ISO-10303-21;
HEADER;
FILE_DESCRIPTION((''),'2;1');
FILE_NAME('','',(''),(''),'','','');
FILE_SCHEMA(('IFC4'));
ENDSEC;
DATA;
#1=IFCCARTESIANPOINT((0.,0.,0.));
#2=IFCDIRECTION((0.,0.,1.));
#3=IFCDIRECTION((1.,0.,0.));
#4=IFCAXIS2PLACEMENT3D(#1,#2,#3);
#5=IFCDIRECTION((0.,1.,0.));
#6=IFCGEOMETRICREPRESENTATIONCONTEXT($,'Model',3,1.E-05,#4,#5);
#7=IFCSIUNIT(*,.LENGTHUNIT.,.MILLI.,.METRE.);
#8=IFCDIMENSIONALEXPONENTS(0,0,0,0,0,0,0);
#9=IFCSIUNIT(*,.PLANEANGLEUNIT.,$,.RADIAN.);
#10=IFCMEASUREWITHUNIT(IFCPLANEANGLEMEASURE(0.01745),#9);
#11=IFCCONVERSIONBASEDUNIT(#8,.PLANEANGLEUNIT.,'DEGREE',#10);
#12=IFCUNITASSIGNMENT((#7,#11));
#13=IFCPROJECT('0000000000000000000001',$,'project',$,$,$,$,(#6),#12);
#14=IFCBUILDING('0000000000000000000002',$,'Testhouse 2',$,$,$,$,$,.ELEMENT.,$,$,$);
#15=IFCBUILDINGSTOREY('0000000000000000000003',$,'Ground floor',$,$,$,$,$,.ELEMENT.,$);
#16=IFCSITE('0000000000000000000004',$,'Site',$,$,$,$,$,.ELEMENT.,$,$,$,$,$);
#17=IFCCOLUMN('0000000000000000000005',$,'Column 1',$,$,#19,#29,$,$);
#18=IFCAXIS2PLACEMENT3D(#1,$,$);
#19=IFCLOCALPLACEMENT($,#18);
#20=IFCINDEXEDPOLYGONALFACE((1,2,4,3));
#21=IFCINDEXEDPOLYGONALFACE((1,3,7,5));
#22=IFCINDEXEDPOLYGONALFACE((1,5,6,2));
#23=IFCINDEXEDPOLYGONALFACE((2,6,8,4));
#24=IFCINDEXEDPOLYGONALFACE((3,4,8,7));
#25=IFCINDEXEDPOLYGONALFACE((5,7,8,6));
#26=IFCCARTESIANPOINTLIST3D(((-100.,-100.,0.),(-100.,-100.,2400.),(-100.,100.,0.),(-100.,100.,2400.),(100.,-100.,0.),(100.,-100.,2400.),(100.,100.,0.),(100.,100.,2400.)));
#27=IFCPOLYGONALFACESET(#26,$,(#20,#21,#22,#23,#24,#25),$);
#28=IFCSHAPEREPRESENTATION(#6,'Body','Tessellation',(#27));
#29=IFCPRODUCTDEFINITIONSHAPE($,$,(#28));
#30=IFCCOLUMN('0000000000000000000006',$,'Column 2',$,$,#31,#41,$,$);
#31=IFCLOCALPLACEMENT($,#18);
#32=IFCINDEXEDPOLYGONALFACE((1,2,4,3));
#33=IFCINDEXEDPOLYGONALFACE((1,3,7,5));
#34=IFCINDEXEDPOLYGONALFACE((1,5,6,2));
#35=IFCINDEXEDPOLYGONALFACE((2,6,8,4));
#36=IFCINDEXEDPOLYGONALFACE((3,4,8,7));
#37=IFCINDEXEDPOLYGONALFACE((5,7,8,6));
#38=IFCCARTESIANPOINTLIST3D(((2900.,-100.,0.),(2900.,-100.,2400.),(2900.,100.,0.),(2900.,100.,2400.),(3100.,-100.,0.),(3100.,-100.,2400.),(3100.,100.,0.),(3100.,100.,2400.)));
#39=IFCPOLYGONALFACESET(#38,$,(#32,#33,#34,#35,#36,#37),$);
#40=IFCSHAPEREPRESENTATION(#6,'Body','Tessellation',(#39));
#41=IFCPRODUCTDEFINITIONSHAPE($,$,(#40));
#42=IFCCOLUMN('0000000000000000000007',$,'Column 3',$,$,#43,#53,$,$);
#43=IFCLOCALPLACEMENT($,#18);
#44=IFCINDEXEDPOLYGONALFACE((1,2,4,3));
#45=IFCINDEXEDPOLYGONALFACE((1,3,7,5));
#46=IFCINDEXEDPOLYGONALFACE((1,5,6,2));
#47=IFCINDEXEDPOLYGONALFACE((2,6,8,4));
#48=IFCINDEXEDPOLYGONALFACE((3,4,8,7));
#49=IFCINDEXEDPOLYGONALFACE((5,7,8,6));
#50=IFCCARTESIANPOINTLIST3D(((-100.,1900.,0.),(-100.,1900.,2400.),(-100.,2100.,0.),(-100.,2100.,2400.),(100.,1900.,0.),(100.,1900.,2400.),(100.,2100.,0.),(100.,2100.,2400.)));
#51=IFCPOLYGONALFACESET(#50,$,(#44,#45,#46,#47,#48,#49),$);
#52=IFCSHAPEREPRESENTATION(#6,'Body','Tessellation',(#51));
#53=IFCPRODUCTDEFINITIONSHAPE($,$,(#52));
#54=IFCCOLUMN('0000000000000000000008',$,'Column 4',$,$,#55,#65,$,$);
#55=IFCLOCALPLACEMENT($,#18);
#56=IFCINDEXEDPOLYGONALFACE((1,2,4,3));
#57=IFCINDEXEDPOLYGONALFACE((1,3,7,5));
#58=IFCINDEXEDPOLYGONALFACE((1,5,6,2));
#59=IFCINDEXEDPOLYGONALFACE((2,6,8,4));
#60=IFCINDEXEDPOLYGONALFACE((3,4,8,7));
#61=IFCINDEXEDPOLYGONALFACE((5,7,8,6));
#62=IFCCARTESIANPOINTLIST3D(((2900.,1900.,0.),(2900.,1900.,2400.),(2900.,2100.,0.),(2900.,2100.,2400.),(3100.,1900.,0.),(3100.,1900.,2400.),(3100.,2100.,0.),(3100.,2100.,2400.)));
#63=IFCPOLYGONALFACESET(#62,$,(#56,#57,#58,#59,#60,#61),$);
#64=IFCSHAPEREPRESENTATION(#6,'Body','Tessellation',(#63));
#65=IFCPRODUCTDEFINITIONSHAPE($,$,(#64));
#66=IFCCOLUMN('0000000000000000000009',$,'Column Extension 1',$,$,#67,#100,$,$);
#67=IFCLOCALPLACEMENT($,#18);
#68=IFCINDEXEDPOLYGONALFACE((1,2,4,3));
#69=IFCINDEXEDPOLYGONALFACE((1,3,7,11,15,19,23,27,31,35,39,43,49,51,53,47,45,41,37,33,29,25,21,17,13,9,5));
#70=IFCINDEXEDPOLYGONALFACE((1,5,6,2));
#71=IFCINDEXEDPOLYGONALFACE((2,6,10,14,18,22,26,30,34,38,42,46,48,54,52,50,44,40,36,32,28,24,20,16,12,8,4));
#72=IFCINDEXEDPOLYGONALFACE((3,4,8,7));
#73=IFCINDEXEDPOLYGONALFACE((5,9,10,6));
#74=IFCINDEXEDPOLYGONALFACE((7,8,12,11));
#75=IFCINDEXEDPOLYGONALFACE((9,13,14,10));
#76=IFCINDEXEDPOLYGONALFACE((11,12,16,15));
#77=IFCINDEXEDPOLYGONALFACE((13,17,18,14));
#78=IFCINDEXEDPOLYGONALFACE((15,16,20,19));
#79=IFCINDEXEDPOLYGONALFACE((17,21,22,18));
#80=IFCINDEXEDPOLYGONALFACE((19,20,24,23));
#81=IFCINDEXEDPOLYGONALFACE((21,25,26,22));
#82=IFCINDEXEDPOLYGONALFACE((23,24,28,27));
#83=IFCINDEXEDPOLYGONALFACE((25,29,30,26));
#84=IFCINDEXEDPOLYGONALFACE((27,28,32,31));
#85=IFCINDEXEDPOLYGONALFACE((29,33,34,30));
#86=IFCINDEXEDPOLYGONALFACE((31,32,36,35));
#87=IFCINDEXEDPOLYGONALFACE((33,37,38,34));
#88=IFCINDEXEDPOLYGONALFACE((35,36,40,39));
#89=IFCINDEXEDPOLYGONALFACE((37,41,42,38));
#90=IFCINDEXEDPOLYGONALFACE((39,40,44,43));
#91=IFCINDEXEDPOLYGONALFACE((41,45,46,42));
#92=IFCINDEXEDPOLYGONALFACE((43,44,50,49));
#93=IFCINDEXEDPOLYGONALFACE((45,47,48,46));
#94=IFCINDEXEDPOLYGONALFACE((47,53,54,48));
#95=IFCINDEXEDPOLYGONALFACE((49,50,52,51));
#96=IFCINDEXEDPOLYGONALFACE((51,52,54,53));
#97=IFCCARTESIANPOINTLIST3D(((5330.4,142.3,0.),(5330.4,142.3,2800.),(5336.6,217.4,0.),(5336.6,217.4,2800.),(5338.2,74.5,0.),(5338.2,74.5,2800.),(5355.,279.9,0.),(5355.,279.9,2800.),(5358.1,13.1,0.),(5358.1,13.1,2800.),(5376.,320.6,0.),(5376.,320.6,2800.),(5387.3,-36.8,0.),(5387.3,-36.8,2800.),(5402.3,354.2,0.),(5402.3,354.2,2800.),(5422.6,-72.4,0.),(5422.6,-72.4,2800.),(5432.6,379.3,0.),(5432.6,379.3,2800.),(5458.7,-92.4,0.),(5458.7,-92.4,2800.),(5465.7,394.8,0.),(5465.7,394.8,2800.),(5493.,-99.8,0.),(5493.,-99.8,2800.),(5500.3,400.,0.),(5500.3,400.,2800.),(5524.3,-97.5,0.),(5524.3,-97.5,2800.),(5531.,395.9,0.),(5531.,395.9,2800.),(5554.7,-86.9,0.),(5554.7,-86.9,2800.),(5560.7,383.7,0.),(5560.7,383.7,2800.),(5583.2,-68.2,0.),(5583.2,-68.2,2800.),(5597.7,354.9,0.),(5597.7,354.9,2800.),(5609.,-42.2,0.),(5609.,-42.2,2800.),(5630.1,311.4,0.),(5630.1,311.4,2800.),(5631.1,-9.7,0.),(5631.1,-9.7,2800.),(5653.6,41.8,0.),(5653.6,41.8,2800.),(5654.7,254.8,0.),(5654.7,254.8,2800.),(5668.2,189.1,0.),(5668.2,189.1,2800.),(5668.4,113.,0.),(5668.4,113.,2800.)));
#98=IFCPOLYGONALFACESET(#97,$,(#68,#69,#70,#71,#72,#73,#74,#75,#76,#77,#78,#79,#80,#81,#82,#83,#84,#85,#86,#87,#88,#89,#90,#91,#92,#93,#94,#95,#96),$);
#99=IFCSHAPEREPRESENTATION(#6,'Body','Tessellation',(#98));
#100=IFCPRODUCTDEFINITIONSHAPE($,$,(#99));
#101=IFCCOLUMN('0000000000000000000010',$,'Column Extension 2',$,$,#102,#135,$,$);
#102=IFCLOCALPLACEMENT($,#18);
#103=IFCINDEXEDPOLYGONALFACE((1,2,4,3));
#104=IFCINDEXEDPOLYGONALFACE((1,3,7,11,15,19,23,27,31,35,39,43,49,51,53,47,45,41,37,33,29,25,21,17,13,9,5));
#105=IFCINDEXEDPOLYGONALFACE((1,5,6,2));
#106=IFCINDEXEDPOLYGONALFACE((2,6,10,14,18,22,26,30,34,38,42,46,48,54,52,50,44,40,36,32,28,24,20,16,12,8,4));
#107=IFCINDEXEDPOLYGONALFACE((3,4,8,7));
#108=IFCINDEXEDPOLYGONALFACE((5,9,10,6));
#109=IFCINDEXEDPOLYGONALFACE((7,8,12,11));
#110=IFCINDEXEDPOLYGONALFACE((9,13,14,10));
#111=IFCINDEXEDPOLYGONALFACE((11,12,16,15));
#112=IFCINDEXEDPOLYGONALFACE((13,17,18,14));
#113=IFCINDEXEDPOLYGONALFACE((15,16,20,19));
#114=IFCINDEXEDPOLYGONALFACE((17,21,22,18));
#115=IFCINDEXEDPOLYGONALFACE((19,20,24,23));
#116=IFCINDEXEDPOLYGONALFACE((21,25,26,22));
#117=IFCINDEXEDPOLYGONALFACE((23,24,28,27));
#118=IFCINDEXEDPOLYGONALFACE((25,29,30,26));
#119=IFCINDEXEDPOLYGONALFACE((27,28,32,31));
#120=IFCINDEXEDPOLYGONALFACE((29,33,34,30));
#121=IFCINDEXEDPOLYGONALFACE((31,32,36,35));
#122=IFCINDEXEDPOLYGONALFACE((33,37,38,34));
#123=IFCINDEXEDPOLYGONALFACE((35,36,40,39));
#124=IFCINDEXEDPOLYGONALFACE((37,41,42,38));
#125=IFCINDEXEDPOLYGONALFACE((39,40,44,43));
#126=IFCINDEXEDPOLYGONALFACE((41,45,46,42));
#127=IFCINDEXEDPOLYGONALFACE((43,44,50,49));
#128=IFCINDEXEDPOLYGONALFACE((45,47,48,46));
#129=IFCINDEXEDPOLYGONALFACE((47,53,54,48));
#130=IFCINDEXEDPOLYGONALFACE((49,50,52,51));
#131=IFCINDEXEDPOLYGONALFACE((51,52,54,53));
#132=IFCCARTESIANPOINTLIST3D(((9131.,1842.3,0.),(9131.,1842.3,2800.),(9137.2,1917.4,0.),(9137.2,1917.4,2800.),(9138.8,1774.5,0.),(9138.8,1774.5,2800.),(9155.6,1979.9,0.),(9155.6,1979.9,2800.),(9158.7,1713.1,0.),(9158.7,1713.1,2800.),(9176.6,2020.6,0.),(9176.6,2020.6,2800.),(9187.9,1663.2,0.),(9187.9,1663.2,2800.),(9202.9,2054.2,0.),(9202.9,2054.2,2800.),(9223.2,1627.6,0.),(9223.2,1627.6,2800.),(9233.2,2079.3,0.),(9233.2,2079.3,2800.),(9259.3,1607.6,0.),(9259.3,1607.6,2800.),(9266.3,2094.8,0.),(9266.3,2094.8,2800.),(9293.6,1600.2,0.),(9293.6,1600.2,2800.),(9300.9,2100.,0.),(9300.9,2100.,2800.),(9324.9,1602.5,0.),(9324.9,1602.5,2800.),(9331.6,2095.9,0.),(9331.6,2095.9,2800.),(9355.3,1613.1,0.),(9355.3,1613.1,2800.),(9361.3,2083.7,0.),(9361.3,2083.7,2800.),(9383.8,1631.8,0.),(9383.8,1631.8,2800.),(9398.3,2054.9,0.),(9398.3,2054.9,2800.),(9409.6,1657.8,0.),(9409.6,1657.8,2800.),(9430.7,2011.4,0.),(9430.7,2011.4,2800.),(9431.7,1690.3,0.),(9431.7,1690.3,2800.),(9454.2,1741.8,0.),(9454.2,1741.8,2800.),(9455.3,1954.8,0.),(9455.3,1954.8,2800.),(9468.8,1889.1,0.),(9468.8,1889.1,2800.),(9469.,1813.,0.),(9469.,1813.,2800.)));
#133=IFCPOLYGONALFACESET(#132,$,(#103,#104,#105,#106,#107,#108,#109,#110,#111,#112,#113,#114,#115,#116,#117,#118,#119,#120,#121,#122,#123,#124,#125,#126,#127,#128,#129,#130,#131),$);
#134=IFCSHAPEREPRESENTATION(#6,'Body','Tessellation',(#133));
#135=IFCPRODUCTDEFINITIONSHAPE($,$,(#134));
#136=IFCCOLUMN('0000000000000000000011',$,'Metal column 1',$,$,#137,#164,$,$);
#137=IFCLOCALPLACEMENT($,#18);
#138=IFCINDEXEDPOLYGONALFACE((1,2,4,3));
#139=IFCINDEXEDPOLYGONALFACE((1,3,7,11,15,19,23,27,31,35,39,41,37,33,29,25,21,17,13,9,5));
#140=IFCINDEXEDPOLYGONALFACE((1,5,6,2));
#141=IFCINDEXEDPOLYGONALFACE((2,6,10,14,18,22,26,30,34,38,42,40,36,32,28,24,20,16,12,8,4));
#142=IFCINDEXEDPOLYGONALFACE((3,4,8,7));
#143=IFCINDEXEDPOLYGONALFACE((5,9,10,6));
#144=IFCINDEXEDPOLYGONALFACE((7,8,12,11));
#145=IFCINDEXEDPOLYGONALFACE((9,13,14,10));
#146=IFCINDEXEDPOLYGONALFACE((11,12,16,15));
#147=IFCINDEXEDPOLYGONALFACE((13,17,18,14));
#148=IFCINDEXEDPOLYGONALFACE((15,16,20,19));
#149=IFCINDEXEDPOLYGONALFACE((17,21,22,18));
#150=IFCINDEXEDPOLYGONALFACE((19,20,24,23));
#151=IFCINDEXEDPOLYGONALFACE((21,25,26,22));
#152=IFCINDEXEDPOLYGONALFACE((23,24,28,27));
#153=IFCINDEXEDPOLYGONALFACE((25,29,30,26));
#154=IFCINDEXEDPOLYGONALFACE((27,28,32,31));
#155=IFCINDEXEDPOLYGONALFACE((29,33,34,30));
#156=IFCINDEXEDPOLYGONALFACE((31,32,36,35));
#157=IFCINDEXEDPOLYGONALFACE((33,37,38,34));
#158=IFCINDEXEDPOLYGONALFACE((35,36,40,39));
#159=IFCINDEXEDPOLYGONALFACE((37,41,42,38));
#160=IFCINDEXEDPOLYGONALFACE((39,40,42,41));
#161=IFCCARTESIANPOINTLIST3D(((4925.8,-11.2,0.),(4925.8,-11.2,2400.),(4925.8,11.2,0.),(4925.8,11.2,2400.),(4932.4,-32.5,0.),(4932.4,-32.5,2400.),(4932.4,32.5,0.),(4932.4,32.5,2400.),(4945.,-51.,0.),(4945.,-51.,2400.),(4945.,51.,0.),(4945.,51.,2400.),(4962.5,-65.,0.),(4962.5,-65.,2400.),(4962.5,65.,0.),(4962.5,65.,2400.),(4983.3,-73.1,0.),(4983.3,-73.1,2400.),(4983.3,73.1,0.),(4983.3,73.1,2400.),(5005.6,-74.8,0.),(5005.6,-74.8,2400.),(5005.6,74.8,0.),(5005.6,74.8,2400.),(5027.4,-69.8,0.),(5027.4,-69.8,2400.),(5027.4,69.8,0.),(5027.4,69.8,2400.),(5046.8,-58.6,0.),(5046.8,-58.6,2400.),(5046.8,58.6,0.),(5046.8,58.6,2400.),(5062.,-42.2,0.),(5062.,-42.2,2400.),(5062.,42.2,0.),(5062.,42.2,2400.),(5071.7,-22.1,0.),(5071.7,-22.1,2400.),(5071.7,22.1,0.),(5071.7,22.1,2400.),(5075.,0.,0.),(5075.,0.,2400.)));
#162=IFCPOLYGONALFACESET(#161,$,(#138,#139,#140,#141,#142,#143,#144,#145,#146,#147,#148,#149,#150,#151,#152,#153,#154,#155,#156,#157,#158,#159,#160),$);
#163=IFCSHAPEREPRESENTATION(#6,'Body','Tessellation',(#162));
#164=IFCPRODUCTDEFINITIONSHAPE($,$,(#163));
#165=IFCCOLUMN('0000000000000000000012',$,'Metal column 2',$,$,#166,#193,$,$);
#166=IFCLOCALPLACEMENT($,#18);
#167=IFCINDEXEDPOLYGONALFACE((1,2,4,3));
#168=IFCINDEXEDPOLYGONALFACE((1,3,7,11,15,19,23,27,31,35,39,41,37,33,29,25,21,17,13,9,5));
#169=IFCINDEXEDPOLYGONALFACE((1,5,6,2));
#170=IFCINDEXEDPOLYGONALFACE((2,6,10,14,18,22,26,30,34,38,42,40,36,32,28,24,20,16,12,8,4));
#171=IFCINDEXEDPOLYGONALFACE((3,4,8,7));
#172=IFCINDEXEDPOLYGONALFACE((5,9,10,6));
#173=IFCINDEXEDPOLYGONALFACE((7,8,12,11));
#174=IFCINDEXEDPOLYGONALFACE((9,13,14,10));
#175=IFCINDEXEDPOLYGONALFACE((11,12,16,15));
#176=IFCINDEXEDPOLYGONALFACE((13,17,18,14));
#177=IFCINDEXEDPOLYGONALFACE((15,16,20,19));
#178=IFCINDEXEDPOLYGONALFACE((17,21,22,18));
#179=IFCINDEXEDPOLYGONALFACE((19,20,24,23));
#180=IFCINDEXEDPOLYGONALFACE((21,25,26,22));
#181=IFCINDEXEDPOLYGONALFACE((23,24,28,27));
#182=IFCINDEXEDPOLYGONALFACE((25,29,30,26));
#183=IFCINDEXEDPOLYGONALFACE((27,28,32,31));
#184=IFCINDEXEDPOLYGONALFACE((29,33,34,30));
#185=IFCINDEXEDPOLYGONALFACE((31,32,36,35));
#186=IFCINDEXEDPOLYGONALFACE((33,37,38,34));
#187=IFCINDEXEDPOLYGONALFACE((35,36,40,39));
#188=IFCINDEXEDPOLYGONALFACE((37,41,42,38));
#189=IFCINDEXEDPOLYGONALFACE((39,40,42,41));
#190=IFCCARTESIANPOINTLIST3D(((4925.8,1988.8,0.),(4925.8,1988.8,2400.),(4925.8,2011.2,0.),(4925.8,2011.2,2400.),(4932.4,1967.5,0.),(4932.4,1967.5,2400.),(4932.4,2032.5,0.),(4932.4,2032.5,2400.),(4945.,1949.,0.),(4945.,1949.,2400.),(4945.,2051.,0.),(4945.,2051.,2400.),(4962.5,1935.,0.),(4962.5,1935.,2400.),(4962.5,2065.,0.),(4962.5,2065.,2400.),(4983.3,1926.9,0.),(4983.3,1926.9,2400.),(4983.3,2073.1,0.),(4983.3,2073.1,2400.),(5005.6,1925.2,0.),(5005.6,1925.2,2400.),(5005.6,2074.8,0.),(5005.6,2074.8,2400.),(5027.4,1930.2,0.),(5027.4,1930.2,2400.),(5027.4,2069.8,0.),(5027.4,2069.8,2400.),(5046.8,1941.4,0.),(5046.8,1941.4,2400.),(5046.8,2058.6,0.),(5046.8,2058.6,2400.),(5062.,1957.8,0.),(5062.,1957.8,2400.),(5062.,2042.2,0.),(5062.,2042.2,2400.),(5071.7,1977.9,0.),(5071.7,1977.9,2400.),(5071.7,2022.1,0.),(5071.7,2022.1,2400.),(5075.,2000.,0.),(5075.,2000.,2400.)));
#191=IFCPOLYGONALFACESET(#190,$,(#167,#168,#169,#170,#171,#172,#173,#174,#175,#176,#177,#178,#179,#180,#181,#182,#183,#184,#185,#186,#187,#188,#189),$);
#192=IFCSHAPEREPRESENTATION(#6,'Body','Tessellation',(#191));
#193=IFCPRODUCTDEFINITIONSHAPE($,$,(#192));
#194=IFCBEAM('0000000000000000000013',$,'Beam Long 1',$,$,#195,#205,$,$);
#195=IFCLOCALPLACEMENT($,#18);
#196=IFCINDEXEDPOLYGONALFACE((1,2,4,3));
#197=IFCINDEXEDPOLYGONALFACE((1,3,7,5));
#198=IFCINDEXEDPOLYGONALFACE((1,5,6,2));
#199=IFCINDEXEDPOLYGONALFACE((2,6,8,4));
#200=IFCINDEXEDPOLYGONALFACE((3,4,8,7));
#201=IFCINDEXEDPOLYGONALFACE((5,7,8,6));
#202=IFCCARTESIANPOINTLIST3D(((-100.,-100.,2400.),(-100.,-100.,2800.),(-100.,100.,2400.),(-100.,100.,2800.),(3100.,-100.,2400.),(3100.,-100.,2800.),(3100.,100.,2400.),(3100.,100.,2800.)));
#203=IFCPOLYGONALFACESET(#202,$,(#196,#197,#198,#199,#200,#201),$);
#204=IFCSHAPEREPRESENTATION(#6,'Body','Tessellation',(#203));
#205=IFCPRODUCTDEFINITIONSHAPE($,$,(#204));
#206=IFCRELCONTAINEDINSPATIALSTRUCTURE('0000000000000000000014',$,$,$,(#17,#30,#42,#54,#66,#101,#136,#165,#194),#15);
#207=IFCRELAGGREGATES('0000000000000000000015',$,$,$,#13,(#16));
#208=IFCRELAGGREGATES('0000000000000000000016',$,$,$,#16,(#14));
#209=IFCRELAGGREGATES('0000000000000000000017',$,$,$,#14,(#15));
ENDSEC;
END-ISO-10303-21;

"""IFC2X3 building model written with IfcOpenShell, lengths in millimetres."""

from ifc_helpers import new_model, entity, si_unit, converted_unit, direction, frame, origin_with_axes, origin_2d_with_axis, place, context, project, spatial, polyline, circle, ellipse, outline, extrude, element, save


model = new_model("IFC2X3")

# Units and contexts
model_context = context("Model", 3, precision=1e-05, world=origin_with_axes(), true_north=direction((0.0, 1.0, 0.0)))
ifc_project = project(units=[si_unit("LENGTHUNIT", "METRE", prefix="MILLI"), converted_unit("PLANEANGLEUNIT", "DEGREE", entity("IfcPlaneAngleMeasure", 0.01745), si_unit("PLANEANGLEUNIT", "RADIAN"), dimensions=[0, 0, 0, 0, 0, 0, 0])], contexts=[model_context])

# Site, building, storey
site = spatial("IfcSite", under=ifc_project, Name="Site", CompositionType="ELEMENT")
building = spatial("IfcBuilding", under=site, Name="Testhouse 2", CompositionType="ELEMENT")
storey = spatial("IfcBuildingStorey", under=building, Name="Ground floor", CompositionType="ELEMENT")

# Columns
column_1_placement = place(None, origin_with_axes())
element("IfcColumn", 1, at=column_1_placement, inside=storey, Name="Column 1", context=model_context, shape_type="SweptSolid", body=[
    extrude(outline(polyline([(-100.0, -100.0), (100.0, -100.0), (100.0, 100.0), (-100.0, 100.0), (-100.0, -100.0)])), origin_with_axes(), (0.0, 0.0, 1.0), 2400.0),
])
column_2_placement = place(None, origin_with_axes())
element("IfcColumn", 2, at=column_2_placement, inside=storey, Name="Column 2", context=model_context, shape_type="SweptSolid", body=[
    extrude(outline(polyline([(-100.0, -100.0), (100.0, -100.0), (100.0, 100.0), (-100.0, 100.0), (-100.0, -100.0)])), frame((3000.0, 0.0, 0.0), z_axis=(0.0, 0.0, 1.0), x_axis=(1.0, 0.0, 0.0)), (0.0, 0.0, 1.0), 2400.0),
])
column_3_placement = place(None, origin_with_axes())
element("IfcColumn", 3, at=column_3_placement, inside=storey, Name="Column 3", context=model_context, shape_type="SweptSolid", body=[
    extrude(outline(polyline([(-100.0, -100.0), (100.0, -100.0), (100.0, 100.0), (-100.0, 100.0), (-100.0, -100.0)])), frame((0.0, 2000.0, 0.0), z_axis=(0.0, 0.0, 1.0), x_axis=(1.0, 0.0, 0.0)), (0.0, 0.0, 1.0), 2400.0),
])
column_4_placement = place(None, origin_with_axes())
element("IfcColumn", 4, at=column_4_placement, inside=storey, Name="Column 4", context=model_context, shape_type="SweptSolid", body=[
    extrude(outline(polyline([(-100.0, -100.0), (100.0, -100.0), (100.0, 100.0), (-100.0, 100.0), (-100.0, -100.0)])), frame((3000.0, 2000.0, 0.0), z_axis=(0.0, 0.0, 1.0), x_axis=(1.0, 0.0, 0.0)), (0.0, 0.0, 1.0), 2400.0),
])
column_5_placement = place(None, origin_with_axes())
element("IfcColumn", 5, at=column_5_placement, inside=storey, Name="Column Extension 1", context=model_context, shape_type="SweptSolid", body=[
    extrude(ellipse(SemiAxis1=250.0, SemiAxis2=170.0, at=origin_2d_with_axis()), frame((5500.3, 150.0, 0.0), z_axis=(0.0, 0.0, 1.0), x_axis=(0.0, 1.0, 0.0)), (0.0, 0.0, 1.0), 2800.0),
])
column_6_placement = place(None, origin_with_axes())
element("IfcColumn", 6, at=column_6_placement, inside=storey, Name="Column Extension 2", context=model_context, shape_type="SweptSolid", body=[
    extrude(ellipse(SemiAxis1=250.0, SemiAxis2=170.0, at=origin_2d_with_axis()), frame((9300.9, 1850.0, 0.0), z_axis=(0.0, 0.0, 1.0), x_axis=(0.0, 1.0, 0.0)), (0.0, 0.0, 1.0), 2800.0),
])
column_7_placement = place(None, origin_with_axes())
element("IfcColumn", 7, at=column_7_placement, inside=storey, Name="Metal column 1", context=model_context, shape_type="SweptSolid", body=[
    extrude(circle(Radius=75.0, at=origin_2d_with_axis()), frame((5000.0, 0.0, 0.0), z_axis=(0.0, 0.0, 1.0), x_axis=(1.0, 0.0, 0.0)), (0.0, 0.0, 1.0), 2400.0),
])
column_8_placement = place(None, origin_with_axes())
element("IfcColumn", 8, at=column_8_placement, inside=storey, Name="Metal column 2", context=model_context, shape_type="SweptSolid", body=[
    extrude(circle(Radius=75.0, at=origin_2d_with_axis()), frame((5000.0, 2000.0, 0.0), z_axis=(0.0, 0.0, 1.0), x_axis=(1.0, 0.0, 0.0)), (0.0, 0.0, 1.0), 2400.0),
])

# Beam
beam_1_placement = place(None, origin_with_axes())
element("IfcBeam", 9, at=beam_1_placement, inside=storey, Name="Beam Long 1", context=model_context, shape_type="SweptSolid", body=[
    extrude(outline(polyline([(-200.0, -100.0), (200.0, -100.0), (200.0, 100.0), (-200.0, 100.0), (-200.0, -100.0)])), frame((-100.0, 0.0, 2600.0), z_axis=(1.0, 0.0, 0.0), x_axis=(0.0, 0.0, -1.0)), (0.0, 0.0, 1.0), 3200.0),
])

save(model, "model.ifc")
